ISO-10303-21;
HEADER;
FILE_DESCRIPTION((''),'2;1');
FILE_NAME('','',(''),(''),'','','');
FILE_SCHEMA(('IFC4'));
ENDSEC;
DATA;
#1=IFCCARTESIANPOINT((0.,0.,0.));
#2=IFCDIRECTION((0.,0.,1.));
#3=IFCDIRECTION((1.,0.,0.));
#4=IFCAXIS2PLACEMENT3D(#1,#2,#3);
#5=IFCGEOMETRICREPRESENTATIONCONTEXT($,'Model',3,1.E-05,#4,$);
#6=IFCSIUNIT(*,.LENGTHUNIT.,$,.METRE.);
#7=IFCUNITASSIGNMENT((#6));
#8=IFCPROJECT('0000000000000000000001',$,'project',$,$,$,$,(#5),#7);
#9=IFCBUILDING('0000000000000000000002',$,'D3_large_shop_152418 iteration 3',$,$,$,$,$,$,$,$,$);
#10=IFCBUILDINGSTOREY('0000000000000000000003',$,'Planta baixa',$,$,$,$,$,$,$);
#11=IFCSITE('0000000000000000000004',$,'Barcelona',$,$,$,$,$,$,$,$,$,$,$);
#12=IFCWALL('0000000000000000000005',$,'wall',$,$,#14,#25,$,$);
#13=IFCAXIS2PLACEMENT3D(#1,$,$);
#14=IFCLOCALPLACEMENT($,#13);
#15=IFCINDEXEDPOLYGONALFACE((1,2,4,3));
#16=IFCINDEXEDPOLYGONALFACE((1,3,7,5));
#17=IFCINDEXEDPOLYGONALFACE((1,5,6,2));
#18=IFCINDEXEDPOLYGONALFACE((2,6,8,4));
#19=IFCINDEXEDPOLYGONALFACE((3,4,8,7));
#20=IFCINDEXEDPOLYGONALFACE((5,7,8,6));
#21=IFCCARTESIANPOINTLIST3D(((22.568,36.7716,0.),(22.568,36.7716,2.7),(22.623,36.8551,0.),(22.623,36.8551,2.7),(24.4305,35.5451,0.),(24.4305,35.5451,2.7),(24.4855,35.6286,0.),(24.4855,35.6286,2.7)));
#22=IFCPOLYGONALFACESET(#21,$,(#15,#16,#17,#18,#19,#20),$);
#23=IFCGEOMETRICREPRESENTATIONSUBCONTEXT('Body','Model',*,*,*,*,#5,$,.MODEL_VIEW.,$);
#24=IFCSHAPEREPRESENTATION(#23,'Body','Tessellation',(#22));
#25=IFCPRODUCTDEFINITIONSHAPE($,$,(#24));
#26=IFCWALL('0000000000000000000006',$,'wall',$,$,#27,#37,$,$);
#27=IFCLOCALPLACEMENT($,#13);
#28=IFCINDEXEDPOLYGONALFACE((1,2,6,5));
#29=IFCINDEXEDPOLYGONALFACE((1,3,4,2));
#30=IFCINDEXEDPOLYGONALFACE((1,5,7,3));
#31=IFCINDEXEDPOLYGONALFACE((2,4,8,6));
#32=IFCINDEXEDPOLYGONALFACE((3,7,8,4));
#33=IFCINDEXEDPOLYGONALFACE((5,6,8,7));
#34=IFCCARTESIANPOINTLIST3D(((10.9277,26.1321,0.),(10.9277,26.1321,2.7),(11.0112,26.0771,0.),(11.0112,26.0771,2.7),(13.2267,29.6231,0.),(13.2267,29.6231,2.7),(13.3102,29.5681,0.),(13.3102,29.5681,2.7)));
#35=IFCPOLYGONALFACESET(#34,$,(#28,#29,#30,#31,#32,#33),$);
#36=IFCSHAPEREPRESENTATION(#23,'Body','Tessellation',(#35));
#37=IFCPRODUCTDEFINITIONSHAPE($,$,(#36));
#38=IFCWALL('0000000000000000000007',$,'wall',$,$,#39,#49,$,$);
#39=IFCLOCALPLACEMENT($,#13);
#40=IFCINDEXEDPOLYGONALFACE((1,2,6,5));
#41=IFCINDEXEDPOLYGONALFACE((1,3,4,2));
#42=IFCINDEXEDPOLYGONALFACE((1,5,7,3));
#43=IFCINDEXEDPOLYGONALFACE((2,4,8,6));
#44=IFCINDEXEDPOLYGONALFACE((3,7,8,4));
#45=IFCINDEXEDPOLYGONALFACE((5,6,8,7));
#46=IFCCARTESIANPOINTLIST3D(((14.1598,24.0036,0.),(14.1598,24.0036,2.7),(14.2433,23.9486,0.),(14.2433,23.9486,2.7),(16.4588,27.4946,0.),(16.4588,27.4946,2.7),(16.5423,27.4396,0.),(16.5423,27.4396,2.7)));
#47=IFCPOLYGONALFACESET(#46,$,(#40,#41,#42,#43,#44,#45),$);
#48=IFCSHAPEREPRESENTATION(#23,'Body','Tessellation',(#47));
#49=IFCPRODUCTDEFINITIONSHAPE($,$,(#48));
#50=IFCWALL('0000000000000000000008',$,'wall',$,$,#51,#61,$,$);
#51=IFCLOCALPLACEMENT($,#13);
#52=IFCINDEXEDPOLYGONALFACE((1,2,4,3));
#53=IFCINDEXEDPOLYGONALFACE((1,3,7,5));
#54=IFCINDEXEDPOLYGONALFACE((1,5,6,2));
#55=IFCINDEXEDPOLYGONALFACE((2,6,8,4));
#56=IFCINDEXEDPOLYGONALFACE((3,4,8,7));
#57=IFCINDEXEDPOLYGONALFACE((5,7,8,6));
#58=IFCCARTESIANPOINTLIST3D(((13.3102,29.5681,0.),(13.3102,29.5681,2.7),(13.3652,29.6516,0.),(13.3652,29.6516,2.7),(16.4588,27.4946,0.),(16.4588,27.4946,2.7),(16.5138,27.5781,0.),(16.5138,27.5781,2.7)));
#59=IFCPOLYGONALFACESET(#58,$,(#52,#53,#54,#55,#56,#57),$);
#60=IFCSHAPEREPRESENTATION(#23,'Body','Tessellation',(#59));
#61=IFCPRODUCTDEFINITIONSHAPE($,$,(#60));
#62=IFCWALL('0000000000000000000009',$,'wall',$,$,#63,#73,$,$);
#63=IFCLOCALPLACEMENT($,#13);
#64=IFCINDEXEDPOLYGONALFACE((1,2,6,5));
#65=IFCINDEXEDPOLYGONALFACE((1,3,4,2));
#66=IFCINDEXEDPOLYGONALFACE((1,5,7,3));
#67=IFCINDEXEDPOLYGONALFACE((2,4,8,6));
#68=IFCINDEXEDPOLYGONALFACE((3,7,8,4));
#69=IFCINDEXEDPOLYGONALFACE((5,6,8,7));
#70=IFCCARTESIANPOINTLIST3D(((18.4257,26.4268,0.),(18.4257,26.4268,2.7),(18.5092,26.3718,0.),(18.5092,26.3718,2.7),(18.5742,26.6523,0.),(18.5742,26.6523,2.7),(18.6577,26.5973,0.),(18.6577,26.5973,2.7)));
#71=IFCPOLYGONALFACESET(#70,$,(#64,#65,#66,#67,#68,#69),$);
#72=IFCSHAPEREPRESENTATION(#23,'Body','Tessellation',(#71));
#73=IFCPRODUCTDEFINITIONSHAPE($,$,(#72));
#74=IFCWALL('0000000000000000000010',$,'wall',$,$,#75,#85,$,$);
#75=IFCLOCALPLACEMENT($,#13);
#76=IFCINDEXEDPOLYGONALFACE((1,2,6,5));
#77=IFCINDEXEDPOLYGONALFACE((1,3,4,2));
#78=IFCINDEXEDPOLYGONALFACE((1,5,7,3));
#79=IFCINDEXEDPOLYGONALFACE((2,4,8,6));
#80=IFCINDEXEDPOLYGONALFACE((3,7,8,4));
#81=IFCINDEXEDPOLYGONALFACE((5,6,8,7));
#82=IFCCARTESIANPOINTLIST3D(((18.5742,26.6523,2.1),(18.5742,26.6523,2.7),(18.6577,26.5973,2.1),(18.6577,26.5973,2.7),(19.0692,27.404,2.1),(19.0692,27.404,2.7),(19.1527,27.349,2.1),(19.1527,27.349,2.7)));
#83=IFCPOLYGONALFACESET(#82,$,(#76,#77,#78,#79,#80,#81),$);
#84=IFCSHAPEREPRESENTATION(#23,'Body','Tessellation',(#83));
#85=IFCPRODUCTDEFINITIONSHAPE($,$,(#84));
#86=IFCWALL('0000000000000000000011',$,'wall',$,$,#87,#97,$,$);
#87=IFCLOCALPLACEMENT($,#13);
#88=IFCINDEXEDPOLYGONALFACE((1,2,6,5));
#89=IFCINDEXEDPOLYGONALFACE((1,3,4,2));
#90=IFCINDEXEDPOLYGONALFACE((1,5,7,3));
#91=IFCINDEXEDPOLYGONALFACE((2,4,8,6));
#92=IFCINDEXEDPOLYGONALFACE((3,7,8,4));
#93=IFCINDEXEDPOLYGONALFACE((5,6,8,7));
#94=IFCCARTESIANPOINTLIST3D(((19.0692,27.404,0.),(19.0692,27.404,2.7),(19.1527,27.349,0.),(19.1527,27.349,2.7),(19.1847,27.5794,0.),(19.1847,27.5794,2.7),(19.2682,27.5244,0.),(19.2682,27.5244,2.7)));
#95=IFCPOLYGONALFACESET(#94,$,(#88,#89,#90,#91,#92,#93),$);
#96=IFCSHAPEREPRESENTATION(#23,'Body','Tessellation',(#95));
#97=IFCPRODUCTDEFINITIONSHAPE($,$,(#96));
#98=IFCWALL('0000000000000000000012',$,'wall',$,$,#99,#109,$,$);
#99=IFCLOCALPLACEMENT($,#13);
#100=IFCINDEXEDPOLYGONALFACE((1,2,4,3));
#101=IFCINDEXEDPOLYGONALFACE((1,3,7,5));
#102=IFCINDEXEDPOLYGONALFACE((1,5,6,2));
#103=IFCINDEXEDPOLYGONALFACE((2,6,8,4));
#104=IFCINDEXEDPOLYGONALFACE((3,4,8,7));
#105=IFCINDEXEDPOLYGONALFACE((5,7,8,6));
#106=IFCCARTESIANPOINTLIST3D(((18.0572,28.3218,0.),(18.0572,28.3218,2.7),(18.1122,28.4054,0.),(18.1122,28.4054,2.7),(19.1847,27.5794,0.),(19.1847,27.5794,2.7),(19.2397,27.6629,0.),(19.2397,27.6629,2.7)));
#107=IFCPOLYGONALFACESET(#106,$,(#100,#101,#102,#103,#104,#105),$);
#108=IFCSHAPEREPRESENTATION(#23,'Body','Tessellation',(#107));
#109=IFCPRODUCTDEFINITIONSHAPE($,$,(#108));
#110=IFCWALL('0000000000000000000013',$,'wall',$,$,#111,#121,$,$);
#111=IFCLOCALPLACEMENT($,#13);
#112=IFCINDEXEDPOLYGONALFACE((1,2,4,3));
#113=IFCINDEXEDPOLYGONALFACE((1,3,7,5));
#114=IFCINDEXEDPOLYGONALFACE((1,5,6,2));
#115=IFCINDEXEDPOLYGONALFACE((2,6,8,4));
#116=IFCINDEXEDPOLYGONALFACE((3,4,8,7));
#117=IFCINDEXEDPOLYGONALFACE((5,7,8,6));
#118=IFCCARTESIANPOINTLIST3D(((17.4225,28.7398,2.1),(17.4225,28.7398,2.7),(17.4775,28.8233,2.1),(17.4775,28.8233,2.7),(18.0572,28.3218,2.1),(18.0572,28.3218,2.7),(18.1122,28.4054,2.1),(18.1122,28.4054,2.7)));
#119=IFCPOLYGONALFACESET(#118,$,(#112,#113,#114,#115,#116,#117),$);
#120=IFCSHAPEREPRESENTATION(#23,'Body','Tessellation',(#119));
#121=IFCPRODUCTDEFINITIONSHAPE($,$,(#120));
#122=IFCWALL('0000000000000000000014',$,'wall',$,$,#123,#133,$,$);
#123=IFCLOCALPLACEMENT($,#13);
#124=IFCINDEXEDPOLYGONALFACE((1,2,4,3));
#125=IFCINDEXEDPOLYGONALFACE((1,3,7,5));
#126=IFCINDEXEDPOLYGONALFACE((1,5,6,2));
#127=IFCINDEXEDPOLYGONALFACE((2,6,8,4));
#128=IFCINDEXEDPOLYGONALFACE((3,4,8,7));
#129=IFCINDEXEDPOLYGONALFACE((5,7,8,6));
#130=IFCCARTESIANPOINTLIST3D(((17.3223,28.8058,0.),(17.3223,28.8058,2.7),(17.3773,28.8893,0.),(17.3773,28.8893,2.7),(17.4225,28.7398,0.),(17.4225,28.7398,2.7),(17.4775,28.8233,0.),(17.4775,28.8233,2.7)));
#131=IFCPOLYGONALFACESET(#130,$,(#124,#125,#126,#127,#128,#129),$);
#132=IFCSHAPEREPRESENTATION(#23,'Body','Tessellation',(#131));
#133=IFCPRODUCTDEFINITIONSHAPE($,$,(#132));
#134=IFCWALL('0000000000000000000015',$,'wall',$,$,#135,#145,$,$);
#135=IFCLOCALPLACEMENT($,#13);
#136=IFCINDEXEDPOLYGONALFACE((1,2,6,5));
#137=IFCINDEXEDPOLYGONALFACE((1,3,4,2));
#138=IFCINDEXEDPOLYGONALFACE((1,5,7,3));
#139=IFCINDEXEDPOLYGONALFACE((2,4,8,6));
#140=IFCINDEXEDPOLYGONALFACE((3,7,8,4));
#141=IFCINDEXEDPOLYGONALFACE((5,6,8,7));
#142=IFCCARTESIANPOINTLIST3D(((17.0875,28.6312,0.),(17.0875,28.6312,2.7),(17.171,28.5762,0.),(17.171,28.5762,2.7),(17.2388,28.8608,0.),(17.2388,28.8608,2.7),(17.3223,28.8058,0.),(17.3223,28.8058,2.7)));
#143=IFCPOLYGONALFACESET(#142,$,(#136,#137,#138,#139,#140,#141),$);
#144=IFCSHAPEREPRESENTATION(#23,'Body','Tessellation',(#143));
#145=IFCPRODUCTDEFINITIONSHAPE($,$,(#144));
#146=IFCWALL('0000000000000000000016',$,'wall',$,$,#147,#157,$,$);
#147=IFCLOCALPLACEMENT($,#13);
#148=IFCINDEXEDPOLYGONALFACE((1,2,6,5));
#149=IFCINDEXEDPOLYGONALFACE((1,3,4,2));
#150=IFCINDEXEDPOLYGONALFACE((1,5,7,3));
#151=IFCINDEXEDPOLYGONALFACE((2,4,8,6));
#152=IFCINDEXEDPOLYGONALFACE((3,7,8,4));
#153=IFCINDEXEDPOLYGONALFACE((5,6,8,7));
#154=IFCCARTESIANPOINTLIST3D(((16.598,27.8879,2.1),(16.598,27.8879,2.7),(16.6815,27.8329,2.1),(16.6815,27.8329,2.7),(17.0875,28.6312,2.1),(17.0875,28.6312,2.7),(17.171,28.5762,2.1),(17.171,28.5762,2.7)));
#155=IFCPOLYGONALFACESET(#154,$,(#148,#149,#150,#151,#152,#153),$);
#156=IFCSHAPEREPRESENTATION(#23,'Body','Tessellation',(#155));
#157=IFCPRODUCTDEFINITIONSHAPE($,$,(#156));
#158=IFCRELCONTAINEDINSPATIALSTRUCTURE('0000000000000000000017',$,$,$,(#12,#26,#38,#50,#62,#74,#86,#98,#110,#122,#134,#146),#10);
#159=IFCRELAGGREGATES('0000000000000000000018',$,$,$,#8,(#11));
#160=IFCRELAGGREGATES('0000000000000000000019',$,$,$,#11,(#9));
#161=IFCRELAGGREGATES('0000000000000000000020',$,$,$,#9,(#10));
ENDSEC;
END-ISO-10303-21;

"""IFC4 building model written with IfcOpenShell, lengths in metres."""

from ifc_helpers import new_model, si_unit, frame, origin, origin_with_axes, place, context, subcontext, project, spatial, polyline, outline, extrude, element, save


model = new_model("IFC4")

# Units and contexts
model_context = context("Model", 3, precision=1e-05, world=origin_with_axes())
body_context = subcontext(model_context, "Body", "Model", "MODEL_VIEW")
ifc_project = project(units=[si_unit("LENGTHUNIT", "METRE")], contexts=[model_context])

# Site, building, storey
site = spatial("IfcSite", under=ifc_project, Name="Barcelona")
building = spatial("IfcBuilding", under=site, Name="D3_large_shop_152418 iteration 3")
storey = spatial("IfcBuildingStorey", under=building, Name="Planta baixa")

# Walls
wall_1_placement = place(None, origin_with_axes())
element("IfcWall", 1, at=wall_1_placement, inside=storey, Name="wall", context=body_context, shape_type="SweptSolid", body=[
    extrude(outline(polyline([(24.4305, 35.5451), (22.568, 36.7716), (22.623, 36.8551), (24.4855, 35.6286), (24.4305, 35.5451)])), origin(), (0.0, 0.0, 1.0), 2.7),
])
wall_2_placement = place(None, origin_with_axes())
element("IfcWall", 2, at=wall_2_placement, inside=storey, Name="wall", context=body_context, shape_type="SweptSolid", body=[
    extrude(outline(polyline([(13.3102, 29.5681), (11.0112, 26.0771), (10.9277, 26.1321), (13.2267, 29.6231), (13.3102, 29.5681)])), origin(), (0.0, 0.0, 1.0), 2.7),
])
wall_3_placement = place(None, origin_with_axes())
element("IfcWall", 3, at=wall_3_placement, inside=storey, Name="wall", context=body_context, shape_type="SweptSolid", body=[
    extrude(outline(polyline([(14.1598, 24.0036), (16.4588, 27.4946), (16.5423, 27.4396), (14.2433, 23.9486), (14.1598, 24.0036)])), origin(), (0.0, 0.0, 1.0), 2.7),
])
wall_4_placement = place(None, origin_with_axes())
element("IfcWall", 4, at=wall_4_placement, inside=storey, Name="wall", context=body_context, shape_type="SweptSolid", body=[
    extrude(outline(polyline([(16.4588, 27.4946), (13.3102, 29.5681), (13.3652, 29.6516), (16.5138, 27.5781), (16.4588, 27.4946)])), origin(), (0.0, 0.0, 1.0), 2.7),
])
wall_5_placement = place(None, origin_with_axes())
element("IfcWall", 5, at=wall_5_placement, inside=storey, Name="wall", context=body_context, shape_type="SweptSolid", body=[
    extrude(outline(polyline([(18.4257, 26.4268), (18.5742, 26.6523), (18.6577, 26.5973), (18.5092, 26.3718), (18.4257, 26.4268)])), origin(), (0.0, 0.0, 1.0), 2.7),
])
wall_6_placement = place(None, origin_with_axes())
element("IfcWall", 6, at=wall_6_placement, inside=storey, Name="wall", context=body_context, shape_type="SweptSolid", body=[
    extrude(outline(polyline([(18.5742, 26.6523), (19.0692, 27.404), (19.1527, 27.349), (18.6577, 26.5973), (18.5742, 26.6523)])), frame((0.0, 0.0, 2.1)), (0.0, 0.0, 1.0), 0.6),
])
wall_7_placement = place(None, origin_with_axes())
element("IfcWall", 7, at=wall_7_placement, inside=storey, Name="wall", context=body_context, shape_type="SweptSolid", body=[
    extrude(outline(polyline([(19.0692, 27.404), (19.1847, 27.5794), (19.2682, 27.5244), (19.1527, 27.349), (19.0692, 27.404)])), origin(), (0.0, 0.0, 1.0), 2.7),
])
wall_8_placement = place(None, origin_with_axes())
element("IfcWall", 8, at=wall_8_placement, inside=storey, Name="wall", context=body_context, shape_type="SweptSolid", body=[
    extrude(outline(polyline([(19.1847, 27.5794), (18.0572, 28.3218), (18.1122, 28.4054), (19.2397, 27.6629), (19.1847, 27.5794)])), origin(), (0.0, 0.0, 1.0), 2.7),
])
wall_9_placement = place(None, origin_with_axes())
element("IfcWall", 9, at=wall_9_placement, inside=storey, Name="wall", context=body_context, shape_type="SweptSolid", body=[
    extrude(outline(polyline([(18.0572, 28.3218), (17.4225, 28.7398), (17.4775, 28.8233), (18.1122, 28.4054), (18.0572, 28.3218)])), frame((0.0, 0.0, 2.1)), (0.0, 0.0, 1.0), 0.6),
])
wall_10_placement = place(None, origin_with_axes())
element("IfcWall", 10, at=wall_10_placement, inside=storey, Name="wall", context=body_context, shape_type="SweptSolid", body=[
    extrude(outline(polyline([(17.4225, 28.7398), (17.3223, 28.8058), (17.3773, 28.8893), (17.4775, 28.8233), (17.4225, 28.7398)])), origin(), (0.0, 0.0, 1.0), 2.7),
])
wall_11_placement = place(None, origin_with_axes())
element("IfcWall", 11, at=wall_11_placement, inside=storey, Name="wall", context=body_context, shape_type="SweptSolid", body=[
    extrude(outline(polyline([(17.3223, 28.8058), (17.171, 28.5762), (17.0875, 28.6312), (17.2388, 28.8608), (17.3223, 28.8058)])), origin(), (0.0, 0.0, 1.0), 2.7),
])
wall_12_placement = place(None, origin_with_axes())
element("IfcWall", 12, at=wall_12_placement, inside=storey, Name="wall", context=body_context, shape_type="SweptSolid", body=[
    extrude(outline(polyline([(17.171, 28.5762), (16.6815, 27.8329), (16.598, 27.8879), (17.0875, 28.6312), (17.171, 28.5762)])), frame((0.0, 0.0, 2.1)), (0.0, 0.0, 1.0), 0.6),
])

save(model, "model.ifc")
